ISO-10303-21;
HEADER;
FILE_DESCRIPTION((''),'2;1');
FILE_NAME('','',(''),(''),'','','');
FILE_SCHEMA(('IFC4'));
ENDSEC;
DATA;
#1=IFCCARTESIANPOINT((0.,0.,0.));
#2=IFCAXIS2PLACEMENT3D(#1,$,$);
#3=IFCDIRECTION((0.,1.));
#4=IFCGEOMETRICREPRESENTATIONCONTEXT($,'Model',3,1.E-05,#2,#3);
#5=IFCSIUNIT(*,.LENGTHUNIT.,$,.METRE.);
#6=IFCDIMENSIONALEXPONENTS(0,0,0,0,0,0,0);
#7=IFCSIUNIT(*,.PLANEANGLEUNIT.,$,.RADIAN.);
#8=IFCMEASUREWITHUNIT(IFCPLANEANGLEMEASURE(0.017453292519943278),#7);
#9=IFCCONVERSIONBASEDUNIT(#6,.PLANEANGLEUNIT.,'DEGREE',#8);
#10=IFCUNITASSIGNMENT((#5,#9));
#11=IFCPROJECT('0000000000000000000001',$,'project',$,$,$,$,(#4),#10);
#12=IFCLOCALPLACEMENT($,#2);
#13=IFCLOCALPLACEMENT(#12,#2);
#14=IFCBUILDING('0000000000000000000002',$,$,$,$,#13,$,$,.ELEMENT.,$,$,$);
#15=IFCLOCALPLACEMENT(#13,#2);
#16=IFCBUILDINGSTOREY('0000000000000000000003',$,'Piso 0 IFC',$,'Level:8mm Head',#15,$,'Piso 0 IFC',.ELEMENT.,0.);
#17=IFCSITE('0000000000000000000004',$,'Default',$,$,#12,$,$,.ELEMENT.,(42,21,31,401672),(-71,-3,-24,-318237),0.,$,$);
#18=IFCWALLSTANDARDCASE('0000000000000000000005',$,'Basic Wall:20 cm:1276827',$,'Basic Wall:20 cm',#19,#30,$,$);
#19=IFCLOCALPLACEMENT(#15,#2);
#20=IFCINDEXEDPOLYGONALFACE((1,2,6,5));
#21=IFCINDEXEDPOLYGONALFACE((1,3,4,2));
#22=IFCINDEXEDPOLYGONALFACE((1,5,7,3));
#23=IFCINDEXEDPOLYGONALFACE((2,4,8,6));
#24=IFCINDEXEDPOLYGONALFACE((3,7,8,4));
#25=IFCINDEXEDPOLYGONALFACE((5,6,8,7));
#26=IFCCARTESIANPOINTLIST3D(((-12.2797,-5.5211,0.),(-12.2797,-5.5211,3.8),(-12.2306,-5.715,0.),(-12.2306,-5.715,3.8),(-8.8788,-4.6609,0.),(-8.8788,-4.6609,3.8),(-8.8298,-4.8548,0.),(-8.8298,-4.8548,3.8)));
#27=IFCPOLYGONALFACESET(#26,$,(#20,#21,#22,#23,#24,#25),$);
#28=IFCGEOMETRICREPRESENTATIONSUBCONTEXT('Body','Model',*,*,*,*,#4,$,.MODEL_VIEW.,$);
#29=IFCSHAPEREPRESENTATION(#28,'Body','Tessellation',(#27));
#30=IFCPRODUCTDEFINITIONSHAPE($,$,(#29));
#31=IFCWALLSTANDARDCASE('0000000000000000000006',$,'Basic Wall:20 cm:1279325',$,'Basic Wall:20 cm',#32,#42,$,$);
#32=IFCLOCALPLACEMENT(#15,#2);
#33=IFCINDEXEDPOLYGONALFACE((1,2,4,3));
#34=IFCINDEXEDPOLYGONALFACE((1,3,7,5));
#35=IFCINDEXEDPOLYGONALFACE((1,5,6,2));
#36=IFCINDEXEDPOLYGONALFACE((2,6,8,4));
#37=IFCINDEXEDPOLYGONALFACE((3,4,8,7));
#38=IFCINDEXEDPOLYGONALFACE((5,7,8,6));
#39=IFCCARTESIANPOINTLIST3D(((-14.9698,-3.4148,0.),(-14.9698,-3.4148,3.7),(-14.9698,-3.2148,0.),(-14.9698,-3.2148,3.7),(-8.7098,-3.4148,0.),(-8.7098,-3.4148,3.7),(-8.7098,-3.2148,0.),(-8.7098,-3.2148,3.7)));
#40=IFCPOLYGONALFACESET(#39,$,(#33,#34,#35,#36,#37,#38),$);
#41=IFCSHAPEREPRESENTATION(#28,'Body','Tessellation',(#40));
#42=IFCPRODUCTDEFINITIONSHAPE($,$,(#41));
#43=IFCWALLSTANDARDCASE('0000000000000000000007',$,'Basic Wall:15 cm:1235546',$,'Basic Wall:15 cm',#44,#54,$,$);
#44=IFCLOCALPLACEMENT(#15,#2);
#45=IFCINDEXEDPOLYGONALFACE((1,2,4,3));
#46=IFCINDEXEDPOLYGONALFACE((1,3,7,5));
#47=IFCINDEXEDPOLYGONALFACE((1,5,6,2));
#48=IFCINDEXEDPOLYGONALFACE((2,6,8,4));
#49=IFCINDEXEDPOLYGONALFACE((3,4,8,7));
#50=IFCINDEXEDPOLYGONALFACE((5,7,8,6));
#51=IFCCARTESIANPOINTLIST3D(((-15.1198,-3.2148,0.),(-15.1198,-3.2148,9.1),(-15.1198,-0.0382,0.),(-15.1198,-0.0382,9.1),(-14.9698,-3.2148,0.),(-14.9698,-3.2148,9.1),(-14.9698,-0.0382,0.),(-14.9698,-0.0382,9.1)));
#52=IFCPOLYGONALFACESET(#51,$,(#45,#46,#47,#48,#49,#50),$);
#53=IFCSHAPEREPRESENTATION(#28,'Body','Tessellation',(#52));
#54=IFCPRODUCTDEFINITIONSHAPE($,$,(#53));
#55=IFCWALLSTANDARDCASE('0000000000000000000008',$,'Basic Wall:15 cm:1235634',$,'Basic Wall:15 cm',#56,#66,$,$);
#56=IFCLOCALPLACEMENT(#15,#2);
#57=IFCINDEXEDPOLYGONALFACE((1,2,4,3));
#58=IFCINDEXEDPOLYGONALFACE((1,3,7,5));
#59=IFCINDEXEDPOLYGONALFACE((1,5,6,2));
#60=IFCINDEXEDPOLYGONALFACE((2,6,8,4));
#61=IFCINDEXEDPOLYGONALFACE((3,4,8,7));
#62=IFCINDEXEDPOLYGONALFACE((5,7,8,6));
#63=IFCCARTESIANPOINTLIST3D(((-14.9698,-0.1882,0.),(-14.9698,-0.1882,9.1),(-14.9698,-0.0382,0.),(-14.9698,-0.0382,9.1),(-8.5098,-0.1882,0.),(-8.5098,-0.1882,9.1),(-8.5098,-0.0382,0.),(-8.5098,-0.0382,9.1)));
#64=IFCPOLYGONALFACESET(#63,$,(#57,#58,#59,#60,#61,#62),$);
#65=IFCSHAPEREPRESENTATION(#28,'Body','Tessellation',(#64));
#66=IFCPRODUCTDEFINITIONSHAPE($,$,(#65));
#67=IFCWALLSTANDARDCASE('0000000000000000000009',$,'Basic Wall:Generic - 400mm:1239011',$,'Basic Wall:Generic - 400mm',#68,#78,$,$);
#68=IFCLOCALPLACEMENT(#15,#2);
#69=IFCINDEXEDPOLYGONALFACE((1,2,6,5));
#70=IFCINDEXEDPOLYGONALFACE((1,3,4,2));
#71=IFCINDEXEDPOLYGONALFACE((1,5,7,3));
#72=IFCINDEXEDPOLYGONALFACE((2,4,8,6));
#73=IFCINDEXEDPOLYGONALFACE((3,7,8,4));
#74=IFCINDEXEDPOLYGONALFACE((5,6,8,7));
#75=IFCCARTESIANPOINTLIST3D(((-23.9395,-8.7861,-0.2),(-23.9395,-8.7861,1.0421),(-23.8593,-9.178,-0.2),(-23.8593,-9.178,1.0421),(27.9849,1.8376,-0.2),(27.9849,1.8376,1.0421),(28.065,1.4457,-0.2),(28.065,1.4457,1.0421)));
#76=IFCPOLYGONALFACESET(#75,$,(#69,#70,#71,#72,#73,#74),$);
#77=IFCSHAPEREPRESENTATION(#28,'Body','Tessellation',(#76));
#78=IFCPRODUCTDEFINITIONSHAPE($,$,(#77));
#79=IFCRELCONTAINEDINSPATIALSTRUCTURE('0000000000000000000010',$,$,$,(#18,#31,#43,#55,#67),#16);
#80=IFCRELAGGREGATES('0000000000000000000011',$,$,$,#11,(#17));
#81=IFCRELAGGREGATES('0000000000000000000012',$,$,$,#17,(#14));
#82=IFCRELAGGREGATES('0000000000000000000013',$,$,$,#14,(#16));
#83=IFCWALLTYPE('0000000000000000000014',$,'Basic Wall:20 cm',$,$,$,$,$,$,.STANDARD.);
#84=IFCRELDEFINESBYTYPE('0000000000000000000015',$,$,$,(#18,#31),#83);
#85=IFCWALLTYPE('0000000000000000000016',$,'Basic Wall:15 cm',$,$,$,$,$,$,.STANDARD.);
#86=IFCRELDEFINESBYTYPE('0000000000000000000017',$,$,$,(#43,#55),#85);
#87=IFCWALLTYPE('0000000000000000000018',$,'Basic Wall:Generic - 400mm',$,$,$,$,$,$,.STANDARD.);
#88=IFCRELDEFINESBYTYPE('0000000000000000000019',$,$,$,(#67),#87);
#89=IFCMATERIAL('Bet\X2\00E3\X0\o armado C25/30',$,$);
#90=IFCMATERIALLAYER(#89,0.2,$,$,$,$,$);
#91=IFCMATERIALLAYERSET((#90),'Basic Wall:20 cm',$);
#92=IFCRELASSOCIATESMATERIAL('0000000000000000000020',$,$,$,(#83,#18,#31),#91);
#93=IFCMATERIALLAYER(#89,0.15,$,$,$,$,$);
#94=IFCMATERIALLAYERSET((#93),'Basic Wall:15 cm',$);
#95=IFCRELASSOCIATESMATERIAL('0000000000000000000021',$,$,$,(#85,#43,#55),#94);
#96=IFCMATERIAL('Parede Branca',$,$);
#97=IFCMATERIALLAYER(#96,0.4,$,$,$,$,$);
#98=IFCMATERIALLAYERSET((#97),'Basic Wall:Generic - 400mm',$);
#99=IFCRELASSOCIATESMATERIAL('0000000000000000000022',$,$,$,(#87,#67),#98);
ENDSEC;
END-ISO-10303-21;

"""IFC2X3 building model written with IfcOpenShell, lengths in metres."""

from ifc_helpers import new_model, entity, si_unit, converted_unit, direction, frame, frame_2d, origin, place, context, subcontext, project, spatial, polyline, rectangle, extrude, clip, bounded_halfspace, material, layer, layer_set, layer_usage, type_object, element, save


model = new_model("IFC2X3")

# Units and contexts
model_context = context("Model", 3, precision=1e-05, world=origin(), true_north=direction((0.0, 1.0)))
body_context = subcontext(model_context, "Body", "Model", "MODEL_VIEW")
ifc_project = project(units=[si_unit("LENGTHUNIT", "METRE"), converted_unit("PLANEANGLEUNIT", "DEGREE", entity("IfcPlaneAngleMeasure", 0.017453292519943278), si_unit("PLANEANGLEUNIT", "RADIAN"), dimensions=[0, 0, 0, 0, 0, 0, 0])], contexts=[model_context])

# Site, building, storey
site_placement = place(None, origin())
site = spatial("IfcSite", under=ifc_project, at=site_placement, Name="Default", CompositionType="ELEMENT", RefLatitude=(42, 21, 31, 401672), RefLongitude=(-71, -3, -24, -318237), RefElevation=0.0)
building_placement = place(site_placement, origin())
building = spatial("IfcBuilding", under=site, at=building_placement, CompositionType="ELEMENT")
storey_placement = place(building_placement, origin())
storey = spatial("IfcBuildingStorey", under=building, at=storey_placement, Name="Piso 0 IFC", ObjectType="Level:8mm Head", LongName="Piso 0 IFC", CompositionType="ELEMENT", Elevation=0.0)

# Walls
ifc_material_1 = material(Name="Betão armado C25/30")
ifc_layer_1 = layer(ifc_material_1, 0.2)
ifc_layer_set_1 = layer_set([ifc_layer_1], Name="Basic Wall:20 cm")
wall_type_1 = type_object("IfcWallType", Name="Basic Wall:20 cm", PredefinedType="STANDARD", material=ifc_layer_set_1)
ifc_layer_usage_1 = layer_usage(ifc_layer_set_1, "AXIS2", "NEGATIVE", 0.1)
wall_1_placement = place(storey_placement, frame((-12.2552, -5.6181, 0.0), z_axis=(0.0, 0.0, 1.0), x_axis=(0.969469, 0.245216, 0.0)))
element("IfcWallStandardCase", 1, at=wall_1_placement, inside=storey, type_object=wall_type_1, material=ifc_layer_usage_1, Name="Basic Wall:20 cm:1276827", ObjectType="Basic Wall:20 cm", context=body_context, shape_type="SweptSolid", body=[
    extrude(rectangle(XDim=3.5079, YDim=0.2, at=frame_2d((1.754, 0.0), x_axis=(-1.0, 0.0))), origin(), (0.0, 0.0, 1.0), 3.8),
])
ifc_layer_usage_2 = layer_usage(ifc_layer_set_1, "AXIS2", "NEGATIVE", 0.1)
wall_2_placement = place(storey_placement, frame((-14.9698, -3.3148, 0.0)))
element("IfcWallStandardCase", 2, at=wall_2_placement, inside=storey, type_object=wall_type_1, material=ifc_layer_usage_2, Name="Basic Wall:20 cm:1279325", ObjectType="Basic Wall:20 cm", context=body_context, shape_type="SweptSolid", body=[
    extrude(rectangle(XDim=6.26, YDim=0.2, at=frame_2d((3.13, 0.0), x_axis=(-1.0, 0.0))), origin(), (0.0, 0.0, 1.0), 3.7),
])
ifc_layer_2 = layer(ifc_material_1, 0.15)
ifc_layer_set_2 = layer_set([ifc_layer_2], Name="Basic Wall:15 cm")
ifc_layer_usage_3 = layer_usage(ifc_layer_set_2, "AXIS2", "NEGATIVE", 0.075)
wall_type_2 = type_object("IfcWallType", Name="Basic Wall:15 cm", PredefinedType="STANDARD", material=ifc_layer_set_2)
wall_3_placement = place(storey_placement, frame((-15.0448, -3.2148, 0.0), z_axis=(0.0, 0.0, 1.0), x_axis=(0.0, 1.0, 0.0)))
element("IfcWallStandardCase", 3, at=wall_3_placement, inside=storey, type_object=wall_type_2, material=ifc_layer_usage_3, Name="Basic Wall:15 cm:1235546", ObjectType="Basic Wall:15 cm", context=body_context, shape_type="Clipping", body=[
    clip(extrude(rectangle(XDim=3.1766, YDim=0.15, at=frame_2d((1.5883, 0.0), x_axis=(-1.0, 0.0))), origin(), (0.0, 0.0, 1.0), 9.1), bounded_halfspace(frame((0.0, -0.075, 9.1), z_axis=(0.0, 0.0, -1.0), x_axis=(0.0, 1.0, 0.0)), True, frame((0.0, -0.075, 9.1)), polyline([(0.0, 0.0), (3.0266, 0.0), (3.1766, 0.0), (3.1766, 0.15), (0.0, 0.15), (0.0, 0.0)]))),
])
ifc_layer_usage_4 = layer_usage(ifc_layer_set_2, "AXIS2", "NEGATIVE", 0.075)
wall_4_placement = place(storey_placement, frame((-14.9698, -0.1132, 0.0)))
element("IfcWallStandardCase", 4, at=wall_4_placement, inside=storey, type_object=wall_type_2, material=ifc_layer_usage_4, Name="Basic Wall:15 cm:1235634", ObjectType="Basic Wall:15 cm", context=body_context, shape_type="Clipping", body=[
    clip(extrude(rectangle(XDim=6.46, YDim=0.15, at=frame_2d((3.23, 0.0), x_axis=(-1.0, 0.0))), origin(), (0.0, 0.0, 1.0), 9.1), bounded_halfspace(frame((0.0, -0.075, 9.1), z_axis=(0.0, 0.0, -1.0), x_axis=(-1.0, 0.0, 0.0)), True, frame((0.0, -0.075, 9.1)), polyline([(0.0, 0.0), (6.26, 0.0), (6.46, 0.0), (6.46, 0.15), (6.26, 0.15), (0.0, 0.15), (0.0, 0.0)]))),
])
ifc_material_2 = material(Name="Parede Branca")
ifc_layer_3 = layer(ifc_material_2, 0.4)
ifc_layer_set_3 = layer_set([ifc_layer_3], Name="Basic Wall:Generic - 400mm")
ifc_layer_usage_5 = layer_usage(ifc_layer_set_3, "AXIS2", "NEGATIVE", 0.2)
wall_type_3 = type_object("IfcWallType", Name="Basic Wall:Generic - 400mm", PredefinedType="STANDARD", material=ifc_layer_set_3)
wall_5_placement = place(storey_placement, frame((-23.8994, -8.982, -0.2), z_axis=(0.0, 0.0, 1.0), x_axis=(0.979705, 0.200447, 0.0)))
element("IfcWallStandardCase", 5, at=wall_5_placement, inside=storey, type_object=wall_type_3, material=ifc_layer_usage_5, Name="Basic Wall:Generic - 400mm:1239011", ObjectType="Basic Wall:Generic - 400mm", context=body_context, shape_type="SweptSolid", body=[
    extrude(rectangle(XDim=53.0, YDim=0.4, at=frame_2d((26.5, 0.0), x_axis=(-1.0, 0.0))), origin(), (0.0, 0.0, 1.0), 1.2421),
])

save(model, "model.ifc")
